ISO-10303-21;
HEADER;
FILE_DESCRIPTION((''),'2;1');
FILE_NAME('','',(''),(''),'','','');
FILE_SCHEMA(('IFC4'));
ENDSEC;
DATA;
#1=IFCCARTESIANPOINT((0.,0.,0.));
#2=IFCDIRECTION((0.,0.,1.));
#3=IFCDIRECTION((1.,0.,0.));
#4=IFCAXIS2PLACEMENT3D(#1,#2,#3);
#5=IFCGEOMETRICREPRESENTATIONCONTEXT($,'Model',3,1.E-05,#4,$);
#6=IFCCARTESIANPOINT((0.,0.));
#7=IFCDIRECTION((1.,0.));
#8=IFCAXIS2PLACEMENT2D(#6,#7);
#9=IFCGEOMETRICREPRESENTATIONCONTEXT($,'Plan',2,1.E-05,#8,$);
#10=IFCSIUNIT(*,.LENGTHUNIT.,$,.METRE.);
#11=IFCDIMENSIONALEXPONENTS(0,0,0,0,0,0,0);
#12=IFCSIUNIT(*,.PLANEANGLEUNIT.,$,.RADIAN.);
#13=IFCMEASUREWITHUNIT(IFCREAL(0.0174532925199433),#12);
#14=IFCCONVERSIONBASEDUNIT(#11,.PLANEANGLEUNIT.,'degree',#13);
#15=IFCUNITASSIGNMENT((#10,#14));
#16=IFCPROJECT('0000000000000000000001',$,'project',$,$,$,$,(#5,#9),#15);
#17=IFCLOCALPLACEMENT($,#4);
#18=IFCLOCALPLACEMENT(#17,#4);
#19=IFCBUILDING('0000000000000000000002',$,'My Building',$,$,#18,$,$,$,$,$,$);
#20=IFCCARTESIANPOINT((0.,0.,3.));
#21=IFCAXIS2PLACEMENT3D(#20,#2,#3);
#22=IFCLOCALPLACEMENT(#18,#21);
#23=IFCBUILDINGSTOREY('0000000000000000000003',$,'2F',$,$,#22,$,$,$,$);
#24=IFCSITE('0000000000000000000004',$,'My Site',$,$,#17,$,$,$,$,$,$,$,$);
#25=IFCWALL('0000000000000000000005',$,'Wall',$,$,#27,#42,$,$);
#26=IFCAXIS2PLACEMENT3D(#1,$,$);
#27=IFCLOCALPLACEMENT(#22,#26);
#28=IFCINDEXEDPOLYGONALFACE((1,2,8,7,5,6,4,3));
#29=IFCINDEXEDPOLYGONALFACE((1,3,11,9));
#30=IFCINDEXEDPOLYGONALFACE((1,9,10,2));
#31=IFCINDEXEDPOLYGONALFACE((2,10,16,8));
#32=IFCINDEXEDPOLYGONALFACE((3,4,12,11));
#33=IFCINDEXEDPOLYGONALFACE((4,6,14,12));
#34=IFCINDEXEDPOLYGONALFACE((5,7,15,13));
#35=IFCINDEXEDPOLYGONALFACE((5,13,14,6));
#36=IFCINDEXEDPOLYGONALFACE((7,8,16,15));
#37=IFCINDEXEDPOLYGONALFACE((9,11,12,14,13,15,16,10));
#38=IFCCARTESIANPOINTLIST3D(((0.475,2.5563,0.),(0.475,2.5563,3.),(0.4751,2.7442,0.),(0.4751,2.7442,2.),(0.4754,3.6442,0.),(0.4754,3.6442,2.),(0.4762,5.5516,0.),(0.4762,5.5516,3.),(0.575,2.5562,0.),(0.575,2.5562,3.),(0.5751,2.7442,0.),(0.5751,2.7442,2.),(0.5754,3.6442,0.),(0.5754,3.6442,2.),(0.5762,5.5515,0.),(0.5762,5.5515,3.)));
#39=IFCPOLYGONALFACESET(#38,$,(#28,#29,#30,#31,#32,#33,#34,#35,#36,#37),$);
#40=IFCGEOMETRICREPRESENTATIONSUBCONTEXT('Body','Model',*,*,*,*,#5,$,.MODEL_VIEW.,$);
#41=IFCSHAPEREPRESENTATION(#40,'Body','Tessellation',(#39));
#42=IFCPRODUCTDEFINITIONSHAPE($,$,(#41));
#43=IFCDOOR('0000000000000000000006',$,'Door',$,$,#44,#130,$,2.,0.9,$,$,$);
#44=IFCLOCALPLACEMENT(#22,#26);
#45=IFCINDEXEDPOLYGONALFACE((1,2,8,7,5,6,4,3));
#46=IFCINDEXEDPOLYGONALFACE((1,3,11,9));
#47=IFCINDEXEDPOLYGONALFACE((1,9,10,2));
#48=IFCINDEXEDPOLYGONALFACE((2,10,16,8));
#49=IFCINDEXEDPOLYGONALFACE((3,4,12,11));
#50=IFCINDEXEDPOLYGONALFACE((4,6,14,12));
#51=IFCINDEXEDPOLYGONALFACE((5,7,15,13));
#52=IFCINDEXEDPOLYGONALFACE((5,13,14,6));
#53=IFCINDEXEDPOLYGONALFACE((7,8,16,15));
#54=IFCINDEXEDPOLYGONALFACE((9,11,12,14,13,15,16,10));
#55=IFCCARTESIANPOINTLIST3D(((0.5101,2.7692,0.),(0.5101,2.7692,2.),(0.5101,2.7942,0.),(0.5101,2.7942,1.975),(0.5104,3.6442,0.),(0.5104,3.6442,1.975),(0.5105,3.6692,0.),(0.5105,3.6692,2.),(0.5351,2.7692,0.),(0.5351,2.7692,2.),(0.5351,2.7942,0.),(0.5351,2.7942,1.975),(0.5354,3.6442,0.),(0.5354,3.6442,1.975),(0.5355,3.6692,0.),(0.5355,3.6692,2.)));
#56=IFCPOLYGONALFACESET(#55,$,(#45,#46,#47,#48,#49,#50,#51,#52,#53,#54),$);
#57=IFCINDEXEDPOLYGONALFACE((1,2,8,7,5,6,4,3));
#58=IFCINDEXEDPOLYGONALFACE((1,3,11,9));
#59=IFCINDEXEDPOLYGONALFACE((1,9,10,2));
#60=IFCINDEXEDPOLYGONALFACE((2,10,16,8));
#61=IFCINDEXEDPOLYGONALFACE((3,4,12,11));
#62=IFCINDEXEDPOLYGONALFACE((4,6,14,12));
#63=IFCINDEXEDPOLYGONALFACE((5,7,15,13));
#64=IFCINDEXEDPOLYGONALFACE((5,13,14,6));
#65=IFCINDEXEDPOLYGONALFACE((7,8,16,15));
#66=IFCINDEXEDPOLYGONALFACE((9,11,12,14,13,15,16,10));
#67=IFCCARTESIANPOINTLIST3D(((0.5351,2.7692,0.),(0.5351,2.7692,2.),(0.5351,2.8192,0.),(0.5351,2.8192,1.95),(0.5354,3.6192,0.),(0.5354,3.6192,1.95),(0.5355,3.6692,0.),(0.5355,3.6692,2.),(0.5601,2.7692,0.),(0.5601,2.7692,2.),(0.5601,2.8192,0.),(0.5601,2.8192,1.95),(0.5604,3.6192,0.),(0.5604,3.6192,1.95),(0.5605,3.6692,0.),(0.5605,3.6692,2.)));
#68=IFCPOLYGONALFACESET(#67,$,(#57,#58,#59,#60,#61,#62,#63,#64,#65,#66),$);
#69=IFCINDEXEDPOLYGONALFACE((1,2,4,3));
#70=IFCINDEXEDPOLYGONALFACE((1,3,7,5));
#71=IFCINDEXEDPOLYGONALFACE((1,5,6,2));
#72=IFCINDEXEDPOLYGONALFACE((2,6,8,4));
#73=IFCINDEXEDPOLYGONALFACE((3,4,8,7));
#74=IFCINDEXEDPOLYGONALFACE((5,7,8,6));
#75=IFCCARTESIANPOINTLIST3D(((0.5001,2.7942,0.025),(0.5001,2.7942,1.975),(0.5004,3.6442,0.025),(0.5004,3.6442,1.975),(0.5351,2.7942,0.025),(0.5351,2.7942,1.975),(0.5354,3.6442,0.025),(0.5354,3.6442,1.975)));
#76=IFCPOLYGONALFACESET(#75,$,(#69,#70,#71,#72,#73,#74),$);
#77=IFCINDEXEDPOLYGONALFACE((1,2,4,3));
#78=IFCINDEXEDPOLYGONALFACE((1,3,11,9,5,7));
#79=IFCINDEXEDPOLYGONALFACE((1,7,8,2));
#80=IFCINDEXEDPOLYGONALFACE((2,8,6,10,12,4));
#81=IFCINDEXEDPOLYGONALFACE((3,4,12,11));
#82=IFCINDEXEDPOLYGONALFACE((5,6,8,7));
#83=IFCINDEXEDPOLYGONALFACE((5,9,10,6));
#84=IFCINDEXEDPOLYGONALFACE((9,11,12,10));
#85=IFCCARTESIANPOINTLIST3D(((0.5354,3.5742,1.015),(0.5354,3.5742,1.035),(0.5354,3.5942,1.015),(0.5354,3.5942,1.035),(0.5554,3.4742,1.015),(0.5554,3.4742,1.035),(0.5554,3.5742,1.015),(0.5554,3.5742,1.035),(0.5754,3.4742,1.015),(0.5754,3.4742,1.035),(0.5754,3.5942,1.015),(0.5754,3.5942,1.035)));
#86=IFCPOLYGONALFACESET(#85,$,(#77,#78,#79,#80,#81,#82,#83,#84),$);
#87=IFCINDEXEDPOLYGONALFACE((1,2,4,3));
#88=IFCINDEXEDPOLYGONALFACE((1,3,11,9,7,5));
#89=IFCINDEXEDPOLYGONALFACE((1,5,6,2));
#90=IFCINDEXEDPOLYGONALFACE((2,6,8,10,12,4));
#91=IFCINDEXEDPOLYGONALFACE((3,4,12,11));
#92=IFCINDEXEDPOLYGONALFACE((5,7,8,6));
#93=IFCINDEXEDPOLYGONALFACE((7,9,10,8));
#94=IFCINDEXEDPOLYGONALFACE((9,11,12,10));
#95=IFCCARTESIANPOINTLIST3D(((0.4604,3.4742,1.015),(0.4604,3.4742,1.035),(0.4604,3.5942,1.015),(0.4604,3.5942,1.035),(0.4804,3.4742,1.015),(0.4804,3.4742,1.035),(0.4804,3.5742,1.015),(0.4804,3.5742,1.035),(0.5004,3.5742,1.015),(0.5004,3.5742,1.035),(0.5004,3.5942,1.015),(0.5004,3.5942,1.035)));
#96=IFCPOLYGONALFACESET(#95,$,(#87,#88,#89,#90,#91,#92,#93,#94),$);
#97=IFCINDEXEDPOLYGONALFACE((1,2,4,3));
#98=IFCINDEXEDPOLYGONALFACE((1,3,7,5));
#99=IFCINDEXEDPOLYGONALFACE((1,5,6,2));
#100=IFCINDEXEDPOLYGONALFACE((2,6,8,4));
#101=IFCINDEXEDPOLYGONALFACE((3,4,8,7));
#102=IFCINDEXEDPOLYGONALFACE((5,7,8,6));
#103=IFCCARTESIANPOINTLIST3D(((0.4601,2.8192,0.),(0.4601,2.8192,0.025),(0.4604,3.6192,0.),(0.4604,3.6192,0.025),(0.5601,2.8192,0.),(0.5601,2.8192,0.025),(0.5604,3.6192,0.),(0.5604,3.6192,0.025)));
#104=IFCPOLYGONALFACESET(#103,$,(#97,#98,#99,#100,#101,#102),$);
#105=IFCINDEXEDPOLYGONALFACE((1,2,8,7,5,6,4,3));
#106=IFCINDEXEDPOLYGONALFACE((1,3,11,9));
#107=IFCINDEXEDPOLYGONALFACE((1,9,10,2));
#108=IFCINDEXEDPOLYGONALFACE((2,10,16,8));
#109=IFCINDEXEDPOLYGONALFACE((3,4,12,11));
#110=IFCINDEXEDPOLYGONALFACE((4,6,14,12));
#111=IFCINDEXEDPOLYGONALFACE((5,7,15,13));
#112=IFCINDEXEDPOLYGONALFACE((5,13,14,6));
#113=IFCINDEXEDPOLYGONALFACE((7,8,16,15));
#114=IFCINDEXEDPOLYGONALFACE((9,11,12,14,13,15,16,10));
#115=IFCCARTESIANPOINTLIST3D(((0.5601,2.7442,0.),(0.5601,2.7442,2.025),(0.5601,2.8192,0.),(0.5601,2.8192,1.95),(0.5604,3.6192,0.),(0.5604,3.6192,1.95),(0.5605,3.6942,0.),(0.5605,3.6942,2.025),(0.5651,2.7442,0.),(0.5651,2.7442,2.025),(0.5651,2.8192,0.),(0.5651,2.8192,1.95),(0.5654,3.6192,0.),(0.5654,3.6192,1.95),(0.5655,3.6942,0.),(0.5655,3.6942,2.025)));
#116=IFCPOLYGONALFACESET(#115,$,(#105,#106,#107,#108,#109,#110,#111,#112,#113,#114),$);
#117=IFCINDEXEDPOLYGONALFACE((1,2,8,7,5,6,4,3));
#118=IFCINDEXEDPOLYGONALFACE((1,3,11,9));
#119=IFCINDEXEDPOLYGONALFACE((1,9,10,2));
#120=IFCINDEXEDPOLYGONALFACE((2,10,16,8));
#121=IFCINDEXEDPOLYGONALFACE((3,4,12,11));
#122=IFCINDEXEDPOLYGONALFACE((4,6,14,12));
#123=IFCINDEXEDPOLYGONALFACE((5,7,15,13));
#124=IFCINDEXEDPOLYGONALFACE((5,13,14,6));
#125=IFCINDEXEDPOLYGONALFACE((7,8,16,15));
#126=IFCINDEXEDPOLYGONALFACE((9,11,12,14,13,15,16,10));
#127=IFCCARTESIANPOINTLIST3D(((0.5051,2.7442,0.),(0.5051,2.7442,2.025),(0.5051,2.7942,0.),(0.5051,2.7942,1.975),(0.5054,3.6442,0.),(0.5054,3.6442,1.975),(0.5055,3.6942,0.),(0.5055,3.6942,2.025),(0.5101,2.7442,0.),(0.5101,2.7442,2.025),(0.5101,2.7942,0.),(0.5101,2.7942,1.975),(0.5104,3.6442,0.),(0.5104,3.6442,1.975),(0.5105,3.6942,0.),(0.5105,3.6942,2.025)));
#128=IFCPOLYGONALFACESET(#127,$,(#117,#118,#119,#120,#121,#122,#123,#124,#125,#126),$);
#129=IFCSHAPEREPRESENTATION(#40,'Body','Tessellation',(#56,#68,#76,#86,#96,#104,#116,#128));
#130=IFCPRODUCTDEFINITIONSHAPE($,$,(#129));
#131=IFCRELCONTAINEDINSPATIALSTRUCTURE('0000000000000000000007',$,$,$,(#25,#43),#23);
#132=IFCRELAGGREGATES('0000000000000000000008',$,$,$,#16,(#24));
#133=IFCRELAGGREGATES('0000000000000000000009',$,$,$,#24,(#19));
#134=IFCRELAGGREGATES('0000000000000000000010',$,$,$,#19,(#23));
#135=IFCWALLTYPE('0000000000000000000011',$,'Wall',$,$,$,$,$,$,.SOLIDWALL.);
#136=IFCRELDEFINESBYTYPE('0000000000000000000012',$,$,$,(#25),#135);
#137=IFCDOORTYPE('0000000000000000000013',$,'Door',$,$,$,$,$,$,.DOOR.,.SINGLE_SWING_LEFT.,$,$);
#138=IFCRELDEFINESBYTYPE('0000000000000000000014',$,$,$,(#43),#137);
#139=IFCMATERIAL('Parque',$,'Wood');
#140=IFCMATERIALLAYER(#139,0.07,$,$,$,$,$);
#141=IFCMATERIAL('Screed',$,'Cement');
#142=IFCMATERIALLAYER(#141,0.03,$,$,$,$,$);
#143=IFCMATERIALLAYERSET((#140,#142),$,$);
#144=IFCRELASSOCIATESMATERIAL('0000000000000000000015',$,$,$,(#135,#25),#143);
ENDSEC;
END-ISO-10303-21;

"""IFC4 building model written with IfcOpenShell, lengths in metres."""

from ifc_helpers import new_model, entity, si_unit, converted_unit, frame, origin_with_axes, origin_2d_with_axis, place, context, subcontext, project, spatial, line, indexed_curve, outline, extrude, shape, source, transform, mapped, material, layer, layer_set, layer_usage, type_object, type_shapes, element, fill, save


model = new_model("IFC4")

# Units and contexts
model_context = context("Model", 3, precision=1e-05, world=origin_with_axes())
plan_context = context("Plan", 2, precision=1e-05, world=origin_2d_with_axis())
body_context_1 = subcontext(model_context, "Body", "Model", "MODEL_VIEW")
body_context_2 = subcontext(plan_context, "Body", "Plan", "PLAN_VIEW")
ifc_project = project(units=[si_unit("LENGTHUNIT", "METRE"), converted_unit("PLANEANGLEUNIT", "degree", entity("IfcReal", 0.0174532925199433), si_unit("PLANEANGLEUNIT", "RADIAN"), dimensions=[0, 0, 0, 0, 0, 0, 0])], contexts=[model_context, plan_context])

# Site, building, storey
site_placement = place(None, origin_with_axes())
site = spatial("IfcSite", under=ifc_project, at=site_placement, Name="My Site")
building_placement = place(site_placement, origin_with_axes())
building = spatial("IfcBuilding", under=site, at=building_placement, Name="My Building")
storey_placement = place(building_placement, frame((0.0, 0.0, 3.0), z_axis=(0.0, 0.0, 1.0), x_axis=(1.0, 0.0, 0.0)))
storey = spatial("IfcBuildingStorey", under=building, at=storey_placement, Name="2F")

# Shared definitions
ifc_material_1 = material(Name="Parque", Category="Wood")
ifc_layer_1 = layer(ifc_material_1, 0.07)
ifc_material_2 = material(Name="Screed", Category="Cement")
ifc_layer_2 = layer(ifc_material_2, 0.03)
ifc_layer_set = layer_set([ifc_layer_1, ifc_layer_2])
wall_type = type_object("IfcWallType", Name="Wall", PredefinedType="SOLIDWALL", material=ifc_layer_set)

# Wall, opening, door
ifc_layer_usage_1 = layer_usage(ifc_layer_set, "AXIS2", "POSITIVE", 0.0)
wall_1_placement = place(storey_placement, frame((0.4762, 5.5516, 0.0), z_axis=(0.0, 0.0, 1.0), x_axis=(-0.000399, -1.0, 0.0)))
wall_1 = element("IfcWall", 1, at=wall_1_placement, inside=storey, type_object=wall_type, material=ifc_layer_usage_1, Name="Wall", context=body_context_1, shape_type="SweptSolid", body=[
    extrude(outline(indexed_curve([(0.0, 0.0), (0.0, 0.1), (2.9953, 0.1), (2.9953, 0.0)], segments=[line(1, 2, 3, 4, 1)])), origin_with_axes(), (0.0, 0.0, 1.0), 3.0),
])
shared_shape_1 = source(origin_with_axes(), body_context_1, "Body", "SweptSolid", [
    extrude(outline(indexed_curve([(0.0, 0.0), (0.9, 0.0), (0.9, 2.0), (0.0, 2.0)], segments=[line(1, 2, 3, 4, 1)])), frame((0.0, -0.6, 0.0), z_axis=(0.0, -1.0, 0.0), x_axis=(1.0, 0.0, 0.0)), (0.0, 0.0, -1.0), 1.2),
])
opening_1_placement = place(wall_1_placement, frame((1.9074, 0.0, 0.0), z_axis=(0.0, 0.0, 1.0), x_axis=(1.0, 0.0, 0.0)))
opening_1 = element("IfcOpeningElement", 2, at=opening_1_placement, cuts=wall_1, PredefinedType="OPENING", context=body_context_1, shape_type="MappedRepresentation", body=[
    mapped(shared_shape_1, transform((0.0, 0.0, 0.0), x_axis=(1.0, 0.0, 0.0), y_axis=(0.0, 1.0, 0.0), z_axis=(0.0, 0.0, 1.0), scale=1.0)),
])
door_type = type_object("IfcDoorType", Name="Door", OperationType="SINGLE_SWING_LEFT", PredefinedType="DOOR")
shared_shape_2 = source(origin_with_axes(), body_context_1, "Body", "SweptSolid", [
    extrude(outline(indexed_curve([(0.0, 0.0), (0.0, 2.0), (0.9, 2.0), (0.9, 0.0), (0.875, 0.0), (0.875, 1.975), (0.025, 1.975), (0.025, 0.0)], segments=[line(1, 2, 3, 4, 5, 6, 7, 8, 1)])), frame((0.0, 0.025, 0.0), z_axis=(0.0, -1.0, 0.0), x_axis=(1.0, 0.0, 0.0)), (0.0, 0.0, -1.0), 0.025),
    extrude(outline(indexed_curve([(0.0, 0.0), (0.0, 2.0), (0.9, 2.0), (0.9, 0.0), (0.85, 0.0), (0.85, 1.95), (0.05, 1.95), (0.05, 0.0)], segments=[line(1, 2, 3, 4, 5, 6, 7, 8, 1)])), frame((0.0, 0.0, 0.0), z_axis=(0.0, -1.0, 0.0), x_axis=(1.0, 0.0, 0.0)), (0.0, 0.0, -1.0), 0.025),
    extrude(outline(indexed_curve([(0.0, 0.0), (0.85, 0.0), (0.85, 0.035), (0.0, 0.035)], segments=[line(1, 2, 3, 4, 1)])), frame((0.025, 0.025, 0.025), z_axis=(0.0, 0.0, 1.0), x_axis=(1.0, 0.0, 0.0)), (0.0, 0.0, 1.0), 1.95),
    extrude(outline(indexed_curve([(0.0, 0.0), (0.0, -0.04), (-0.12, -0.04), (-0.12, -0.02), (-0.02, -0.02), (-0.02, 0.0)], segments=[line(1, 2, 3, 4, 5, 6, 1)])), frame((0.825, 0.025, 1.015), z_axis=(0.0, 0.0, 1.0), x_axis=(1.0, 0.0, 0.0)), (0.0, 0.0, 1.0), 0.02),
    extrude(outline(indexed_curve([(0.0, 0.0), (0.0, 0.04), (-0.12, 0.04), (-0.12, 0.02), (-0.02, 0.02), (-0.02, 0.0)], segments=[line(1, 2, 3, 4, 5, 6, 1)])), frame((0.825, 0.06, 1.015), z_axis=(0.0, 0.0, 1.0), x_axis=(1.0, 0.0, 0.0)), (0.0, 0.0, 1.0), 0.02),
    extrude(outline(indexed_curve([(0.0, 0.0), (0.8, 0.0), (0.8, 0.1), (0.0, 0.1)], segments=[line(1, 2, 3, 4, 1)])), frame((0.05, 0.0, 0.0), z_axis=(0.0, 0.0, 1.0), x_axis=(1.0, 0.0, 0.0)), (0.0, 0.0, 1.0), 0.025),
    extrude(outline(indexed_curve([(0.0, 0.0), (0.0, 2.025), (0.95, 2.025), (0.95, 0.0), (0.875, 0.0), (0.875, 1.95), (0.075, 1.95), (0.075, 0.0)], segments=[line(1, 2, 3, 4, 5, 6, 7, 8, 1)])), frame((-0.025, -0.005, 0.0), z_axis=(0.0, -1.0, 0.0), x_axis=(1.0, 0.0, 0.0)), (0.0, 0.0, -1.0), 0.005),
    extrude(outline(indexed_curve([(0.0, 0.0), (0.0, 2.025), (0.95, 2.025), (0.95, 0.0), (0.9, 0.0), (0.9, 1.975), (0.05, 1.975), (0.05, 0.0)], segments=[line(1, 2, 3, 4, 5, 6, 7, 8, 1)])), frame((-0.025, 0.05, 0.0), z_axis=(0.0, -1.0, 0.0), x_axis=(1.0, 0.0, 0.0)), (0.0, 0.0, -1.0), 0.005),
])
shared_shape_3 = source(origin_with_axes(), body_context_2, "Body", "Curve2D", [
    entity("IfcIndexedPolyCurve", entity("IfcCartesianPointList2D", [[0.0, 0.0], [0.0, 0.05], [0.025, 0.05], [0.025, 0.025], [0.05, 0.025], [0.05, 0.0]]), [entity("IfcLineIndex", [1, 2, 3, 4, 5, 6, 1])]),
    entity("IfcIndexedPolyCurve", entity("IfcCartesianPointList2D", [[0.9, 0.0], [0.9, 0.05], [0.875, 0.05], [0.875, 0.025], [0.85, 0.025], [0.85, 0.0]]), [entity("IfcLineIndex", [1, 2, 3, 4, 5, 6, 1])]),
    entity("IfcTrimmedCurve", entity("IfcEllipse", entity("IfcAxis2Placement2D", entity("IfcCartesianPoint", [0.06, 0.05]), entity("IfcDirection", [1.0, 0.0])), 0.815, 0.85), [entity("IfcCartesianPoint", [0.875, 0.05])], [entity("IfcCartesianPoint", [0.06, 0.9])], True, "CARTESIAN"),
    entity("IfcIndexedPolyCurve", entity("IfcCartesianPointList2D", [[0.025, 0.05], [0.06, 0.05], [0.06, 0.9], [0.025, 0.9]]), [entity("IfcLineIndex", [1, 2, 3, 4, 1])]),
])
type_shapes(door_type, [shared_shape_2, shared_shape_3])
door_1_placement = place(opening_1_placement, frame((0.875, 0.085, 0.0), z_axis=(0.0, 0.0, 1.0), x_axis=(-1.0, 0.0, 0.0)))
door_1 = element("IfcDoor", 3, at=door_1_placement, inside=storey, type_object=door_type, Name="Door", OverallHeight=2.0, OverallWidth=0.9, shapes=[
    shape(body_context_1, "Body", "MappedRepresentation", [mapped(shared_shape_2, transform((0.0, 0.0, 0.0), x_axis=(1.0, 0.0, 0.0), y_axis=(0.0, 1.0, 0.0), z_axis=(0.0, 0.0, 1.0), scale=1.0))]),
    shape(body_context_2, "Body", "MappedRepresentation", [mapped(shared_shape_3, transform((0.0, 0.0, 0.0), x_axis=(1.0, 0.0, 0.0), y_axis=(0.0, 1.0, 0.0), z_axis=(0.0, 0.0, 1.0), scale=1.0))]),
])
fill(opening_1, door_1)

save(model, "model.ifc")
